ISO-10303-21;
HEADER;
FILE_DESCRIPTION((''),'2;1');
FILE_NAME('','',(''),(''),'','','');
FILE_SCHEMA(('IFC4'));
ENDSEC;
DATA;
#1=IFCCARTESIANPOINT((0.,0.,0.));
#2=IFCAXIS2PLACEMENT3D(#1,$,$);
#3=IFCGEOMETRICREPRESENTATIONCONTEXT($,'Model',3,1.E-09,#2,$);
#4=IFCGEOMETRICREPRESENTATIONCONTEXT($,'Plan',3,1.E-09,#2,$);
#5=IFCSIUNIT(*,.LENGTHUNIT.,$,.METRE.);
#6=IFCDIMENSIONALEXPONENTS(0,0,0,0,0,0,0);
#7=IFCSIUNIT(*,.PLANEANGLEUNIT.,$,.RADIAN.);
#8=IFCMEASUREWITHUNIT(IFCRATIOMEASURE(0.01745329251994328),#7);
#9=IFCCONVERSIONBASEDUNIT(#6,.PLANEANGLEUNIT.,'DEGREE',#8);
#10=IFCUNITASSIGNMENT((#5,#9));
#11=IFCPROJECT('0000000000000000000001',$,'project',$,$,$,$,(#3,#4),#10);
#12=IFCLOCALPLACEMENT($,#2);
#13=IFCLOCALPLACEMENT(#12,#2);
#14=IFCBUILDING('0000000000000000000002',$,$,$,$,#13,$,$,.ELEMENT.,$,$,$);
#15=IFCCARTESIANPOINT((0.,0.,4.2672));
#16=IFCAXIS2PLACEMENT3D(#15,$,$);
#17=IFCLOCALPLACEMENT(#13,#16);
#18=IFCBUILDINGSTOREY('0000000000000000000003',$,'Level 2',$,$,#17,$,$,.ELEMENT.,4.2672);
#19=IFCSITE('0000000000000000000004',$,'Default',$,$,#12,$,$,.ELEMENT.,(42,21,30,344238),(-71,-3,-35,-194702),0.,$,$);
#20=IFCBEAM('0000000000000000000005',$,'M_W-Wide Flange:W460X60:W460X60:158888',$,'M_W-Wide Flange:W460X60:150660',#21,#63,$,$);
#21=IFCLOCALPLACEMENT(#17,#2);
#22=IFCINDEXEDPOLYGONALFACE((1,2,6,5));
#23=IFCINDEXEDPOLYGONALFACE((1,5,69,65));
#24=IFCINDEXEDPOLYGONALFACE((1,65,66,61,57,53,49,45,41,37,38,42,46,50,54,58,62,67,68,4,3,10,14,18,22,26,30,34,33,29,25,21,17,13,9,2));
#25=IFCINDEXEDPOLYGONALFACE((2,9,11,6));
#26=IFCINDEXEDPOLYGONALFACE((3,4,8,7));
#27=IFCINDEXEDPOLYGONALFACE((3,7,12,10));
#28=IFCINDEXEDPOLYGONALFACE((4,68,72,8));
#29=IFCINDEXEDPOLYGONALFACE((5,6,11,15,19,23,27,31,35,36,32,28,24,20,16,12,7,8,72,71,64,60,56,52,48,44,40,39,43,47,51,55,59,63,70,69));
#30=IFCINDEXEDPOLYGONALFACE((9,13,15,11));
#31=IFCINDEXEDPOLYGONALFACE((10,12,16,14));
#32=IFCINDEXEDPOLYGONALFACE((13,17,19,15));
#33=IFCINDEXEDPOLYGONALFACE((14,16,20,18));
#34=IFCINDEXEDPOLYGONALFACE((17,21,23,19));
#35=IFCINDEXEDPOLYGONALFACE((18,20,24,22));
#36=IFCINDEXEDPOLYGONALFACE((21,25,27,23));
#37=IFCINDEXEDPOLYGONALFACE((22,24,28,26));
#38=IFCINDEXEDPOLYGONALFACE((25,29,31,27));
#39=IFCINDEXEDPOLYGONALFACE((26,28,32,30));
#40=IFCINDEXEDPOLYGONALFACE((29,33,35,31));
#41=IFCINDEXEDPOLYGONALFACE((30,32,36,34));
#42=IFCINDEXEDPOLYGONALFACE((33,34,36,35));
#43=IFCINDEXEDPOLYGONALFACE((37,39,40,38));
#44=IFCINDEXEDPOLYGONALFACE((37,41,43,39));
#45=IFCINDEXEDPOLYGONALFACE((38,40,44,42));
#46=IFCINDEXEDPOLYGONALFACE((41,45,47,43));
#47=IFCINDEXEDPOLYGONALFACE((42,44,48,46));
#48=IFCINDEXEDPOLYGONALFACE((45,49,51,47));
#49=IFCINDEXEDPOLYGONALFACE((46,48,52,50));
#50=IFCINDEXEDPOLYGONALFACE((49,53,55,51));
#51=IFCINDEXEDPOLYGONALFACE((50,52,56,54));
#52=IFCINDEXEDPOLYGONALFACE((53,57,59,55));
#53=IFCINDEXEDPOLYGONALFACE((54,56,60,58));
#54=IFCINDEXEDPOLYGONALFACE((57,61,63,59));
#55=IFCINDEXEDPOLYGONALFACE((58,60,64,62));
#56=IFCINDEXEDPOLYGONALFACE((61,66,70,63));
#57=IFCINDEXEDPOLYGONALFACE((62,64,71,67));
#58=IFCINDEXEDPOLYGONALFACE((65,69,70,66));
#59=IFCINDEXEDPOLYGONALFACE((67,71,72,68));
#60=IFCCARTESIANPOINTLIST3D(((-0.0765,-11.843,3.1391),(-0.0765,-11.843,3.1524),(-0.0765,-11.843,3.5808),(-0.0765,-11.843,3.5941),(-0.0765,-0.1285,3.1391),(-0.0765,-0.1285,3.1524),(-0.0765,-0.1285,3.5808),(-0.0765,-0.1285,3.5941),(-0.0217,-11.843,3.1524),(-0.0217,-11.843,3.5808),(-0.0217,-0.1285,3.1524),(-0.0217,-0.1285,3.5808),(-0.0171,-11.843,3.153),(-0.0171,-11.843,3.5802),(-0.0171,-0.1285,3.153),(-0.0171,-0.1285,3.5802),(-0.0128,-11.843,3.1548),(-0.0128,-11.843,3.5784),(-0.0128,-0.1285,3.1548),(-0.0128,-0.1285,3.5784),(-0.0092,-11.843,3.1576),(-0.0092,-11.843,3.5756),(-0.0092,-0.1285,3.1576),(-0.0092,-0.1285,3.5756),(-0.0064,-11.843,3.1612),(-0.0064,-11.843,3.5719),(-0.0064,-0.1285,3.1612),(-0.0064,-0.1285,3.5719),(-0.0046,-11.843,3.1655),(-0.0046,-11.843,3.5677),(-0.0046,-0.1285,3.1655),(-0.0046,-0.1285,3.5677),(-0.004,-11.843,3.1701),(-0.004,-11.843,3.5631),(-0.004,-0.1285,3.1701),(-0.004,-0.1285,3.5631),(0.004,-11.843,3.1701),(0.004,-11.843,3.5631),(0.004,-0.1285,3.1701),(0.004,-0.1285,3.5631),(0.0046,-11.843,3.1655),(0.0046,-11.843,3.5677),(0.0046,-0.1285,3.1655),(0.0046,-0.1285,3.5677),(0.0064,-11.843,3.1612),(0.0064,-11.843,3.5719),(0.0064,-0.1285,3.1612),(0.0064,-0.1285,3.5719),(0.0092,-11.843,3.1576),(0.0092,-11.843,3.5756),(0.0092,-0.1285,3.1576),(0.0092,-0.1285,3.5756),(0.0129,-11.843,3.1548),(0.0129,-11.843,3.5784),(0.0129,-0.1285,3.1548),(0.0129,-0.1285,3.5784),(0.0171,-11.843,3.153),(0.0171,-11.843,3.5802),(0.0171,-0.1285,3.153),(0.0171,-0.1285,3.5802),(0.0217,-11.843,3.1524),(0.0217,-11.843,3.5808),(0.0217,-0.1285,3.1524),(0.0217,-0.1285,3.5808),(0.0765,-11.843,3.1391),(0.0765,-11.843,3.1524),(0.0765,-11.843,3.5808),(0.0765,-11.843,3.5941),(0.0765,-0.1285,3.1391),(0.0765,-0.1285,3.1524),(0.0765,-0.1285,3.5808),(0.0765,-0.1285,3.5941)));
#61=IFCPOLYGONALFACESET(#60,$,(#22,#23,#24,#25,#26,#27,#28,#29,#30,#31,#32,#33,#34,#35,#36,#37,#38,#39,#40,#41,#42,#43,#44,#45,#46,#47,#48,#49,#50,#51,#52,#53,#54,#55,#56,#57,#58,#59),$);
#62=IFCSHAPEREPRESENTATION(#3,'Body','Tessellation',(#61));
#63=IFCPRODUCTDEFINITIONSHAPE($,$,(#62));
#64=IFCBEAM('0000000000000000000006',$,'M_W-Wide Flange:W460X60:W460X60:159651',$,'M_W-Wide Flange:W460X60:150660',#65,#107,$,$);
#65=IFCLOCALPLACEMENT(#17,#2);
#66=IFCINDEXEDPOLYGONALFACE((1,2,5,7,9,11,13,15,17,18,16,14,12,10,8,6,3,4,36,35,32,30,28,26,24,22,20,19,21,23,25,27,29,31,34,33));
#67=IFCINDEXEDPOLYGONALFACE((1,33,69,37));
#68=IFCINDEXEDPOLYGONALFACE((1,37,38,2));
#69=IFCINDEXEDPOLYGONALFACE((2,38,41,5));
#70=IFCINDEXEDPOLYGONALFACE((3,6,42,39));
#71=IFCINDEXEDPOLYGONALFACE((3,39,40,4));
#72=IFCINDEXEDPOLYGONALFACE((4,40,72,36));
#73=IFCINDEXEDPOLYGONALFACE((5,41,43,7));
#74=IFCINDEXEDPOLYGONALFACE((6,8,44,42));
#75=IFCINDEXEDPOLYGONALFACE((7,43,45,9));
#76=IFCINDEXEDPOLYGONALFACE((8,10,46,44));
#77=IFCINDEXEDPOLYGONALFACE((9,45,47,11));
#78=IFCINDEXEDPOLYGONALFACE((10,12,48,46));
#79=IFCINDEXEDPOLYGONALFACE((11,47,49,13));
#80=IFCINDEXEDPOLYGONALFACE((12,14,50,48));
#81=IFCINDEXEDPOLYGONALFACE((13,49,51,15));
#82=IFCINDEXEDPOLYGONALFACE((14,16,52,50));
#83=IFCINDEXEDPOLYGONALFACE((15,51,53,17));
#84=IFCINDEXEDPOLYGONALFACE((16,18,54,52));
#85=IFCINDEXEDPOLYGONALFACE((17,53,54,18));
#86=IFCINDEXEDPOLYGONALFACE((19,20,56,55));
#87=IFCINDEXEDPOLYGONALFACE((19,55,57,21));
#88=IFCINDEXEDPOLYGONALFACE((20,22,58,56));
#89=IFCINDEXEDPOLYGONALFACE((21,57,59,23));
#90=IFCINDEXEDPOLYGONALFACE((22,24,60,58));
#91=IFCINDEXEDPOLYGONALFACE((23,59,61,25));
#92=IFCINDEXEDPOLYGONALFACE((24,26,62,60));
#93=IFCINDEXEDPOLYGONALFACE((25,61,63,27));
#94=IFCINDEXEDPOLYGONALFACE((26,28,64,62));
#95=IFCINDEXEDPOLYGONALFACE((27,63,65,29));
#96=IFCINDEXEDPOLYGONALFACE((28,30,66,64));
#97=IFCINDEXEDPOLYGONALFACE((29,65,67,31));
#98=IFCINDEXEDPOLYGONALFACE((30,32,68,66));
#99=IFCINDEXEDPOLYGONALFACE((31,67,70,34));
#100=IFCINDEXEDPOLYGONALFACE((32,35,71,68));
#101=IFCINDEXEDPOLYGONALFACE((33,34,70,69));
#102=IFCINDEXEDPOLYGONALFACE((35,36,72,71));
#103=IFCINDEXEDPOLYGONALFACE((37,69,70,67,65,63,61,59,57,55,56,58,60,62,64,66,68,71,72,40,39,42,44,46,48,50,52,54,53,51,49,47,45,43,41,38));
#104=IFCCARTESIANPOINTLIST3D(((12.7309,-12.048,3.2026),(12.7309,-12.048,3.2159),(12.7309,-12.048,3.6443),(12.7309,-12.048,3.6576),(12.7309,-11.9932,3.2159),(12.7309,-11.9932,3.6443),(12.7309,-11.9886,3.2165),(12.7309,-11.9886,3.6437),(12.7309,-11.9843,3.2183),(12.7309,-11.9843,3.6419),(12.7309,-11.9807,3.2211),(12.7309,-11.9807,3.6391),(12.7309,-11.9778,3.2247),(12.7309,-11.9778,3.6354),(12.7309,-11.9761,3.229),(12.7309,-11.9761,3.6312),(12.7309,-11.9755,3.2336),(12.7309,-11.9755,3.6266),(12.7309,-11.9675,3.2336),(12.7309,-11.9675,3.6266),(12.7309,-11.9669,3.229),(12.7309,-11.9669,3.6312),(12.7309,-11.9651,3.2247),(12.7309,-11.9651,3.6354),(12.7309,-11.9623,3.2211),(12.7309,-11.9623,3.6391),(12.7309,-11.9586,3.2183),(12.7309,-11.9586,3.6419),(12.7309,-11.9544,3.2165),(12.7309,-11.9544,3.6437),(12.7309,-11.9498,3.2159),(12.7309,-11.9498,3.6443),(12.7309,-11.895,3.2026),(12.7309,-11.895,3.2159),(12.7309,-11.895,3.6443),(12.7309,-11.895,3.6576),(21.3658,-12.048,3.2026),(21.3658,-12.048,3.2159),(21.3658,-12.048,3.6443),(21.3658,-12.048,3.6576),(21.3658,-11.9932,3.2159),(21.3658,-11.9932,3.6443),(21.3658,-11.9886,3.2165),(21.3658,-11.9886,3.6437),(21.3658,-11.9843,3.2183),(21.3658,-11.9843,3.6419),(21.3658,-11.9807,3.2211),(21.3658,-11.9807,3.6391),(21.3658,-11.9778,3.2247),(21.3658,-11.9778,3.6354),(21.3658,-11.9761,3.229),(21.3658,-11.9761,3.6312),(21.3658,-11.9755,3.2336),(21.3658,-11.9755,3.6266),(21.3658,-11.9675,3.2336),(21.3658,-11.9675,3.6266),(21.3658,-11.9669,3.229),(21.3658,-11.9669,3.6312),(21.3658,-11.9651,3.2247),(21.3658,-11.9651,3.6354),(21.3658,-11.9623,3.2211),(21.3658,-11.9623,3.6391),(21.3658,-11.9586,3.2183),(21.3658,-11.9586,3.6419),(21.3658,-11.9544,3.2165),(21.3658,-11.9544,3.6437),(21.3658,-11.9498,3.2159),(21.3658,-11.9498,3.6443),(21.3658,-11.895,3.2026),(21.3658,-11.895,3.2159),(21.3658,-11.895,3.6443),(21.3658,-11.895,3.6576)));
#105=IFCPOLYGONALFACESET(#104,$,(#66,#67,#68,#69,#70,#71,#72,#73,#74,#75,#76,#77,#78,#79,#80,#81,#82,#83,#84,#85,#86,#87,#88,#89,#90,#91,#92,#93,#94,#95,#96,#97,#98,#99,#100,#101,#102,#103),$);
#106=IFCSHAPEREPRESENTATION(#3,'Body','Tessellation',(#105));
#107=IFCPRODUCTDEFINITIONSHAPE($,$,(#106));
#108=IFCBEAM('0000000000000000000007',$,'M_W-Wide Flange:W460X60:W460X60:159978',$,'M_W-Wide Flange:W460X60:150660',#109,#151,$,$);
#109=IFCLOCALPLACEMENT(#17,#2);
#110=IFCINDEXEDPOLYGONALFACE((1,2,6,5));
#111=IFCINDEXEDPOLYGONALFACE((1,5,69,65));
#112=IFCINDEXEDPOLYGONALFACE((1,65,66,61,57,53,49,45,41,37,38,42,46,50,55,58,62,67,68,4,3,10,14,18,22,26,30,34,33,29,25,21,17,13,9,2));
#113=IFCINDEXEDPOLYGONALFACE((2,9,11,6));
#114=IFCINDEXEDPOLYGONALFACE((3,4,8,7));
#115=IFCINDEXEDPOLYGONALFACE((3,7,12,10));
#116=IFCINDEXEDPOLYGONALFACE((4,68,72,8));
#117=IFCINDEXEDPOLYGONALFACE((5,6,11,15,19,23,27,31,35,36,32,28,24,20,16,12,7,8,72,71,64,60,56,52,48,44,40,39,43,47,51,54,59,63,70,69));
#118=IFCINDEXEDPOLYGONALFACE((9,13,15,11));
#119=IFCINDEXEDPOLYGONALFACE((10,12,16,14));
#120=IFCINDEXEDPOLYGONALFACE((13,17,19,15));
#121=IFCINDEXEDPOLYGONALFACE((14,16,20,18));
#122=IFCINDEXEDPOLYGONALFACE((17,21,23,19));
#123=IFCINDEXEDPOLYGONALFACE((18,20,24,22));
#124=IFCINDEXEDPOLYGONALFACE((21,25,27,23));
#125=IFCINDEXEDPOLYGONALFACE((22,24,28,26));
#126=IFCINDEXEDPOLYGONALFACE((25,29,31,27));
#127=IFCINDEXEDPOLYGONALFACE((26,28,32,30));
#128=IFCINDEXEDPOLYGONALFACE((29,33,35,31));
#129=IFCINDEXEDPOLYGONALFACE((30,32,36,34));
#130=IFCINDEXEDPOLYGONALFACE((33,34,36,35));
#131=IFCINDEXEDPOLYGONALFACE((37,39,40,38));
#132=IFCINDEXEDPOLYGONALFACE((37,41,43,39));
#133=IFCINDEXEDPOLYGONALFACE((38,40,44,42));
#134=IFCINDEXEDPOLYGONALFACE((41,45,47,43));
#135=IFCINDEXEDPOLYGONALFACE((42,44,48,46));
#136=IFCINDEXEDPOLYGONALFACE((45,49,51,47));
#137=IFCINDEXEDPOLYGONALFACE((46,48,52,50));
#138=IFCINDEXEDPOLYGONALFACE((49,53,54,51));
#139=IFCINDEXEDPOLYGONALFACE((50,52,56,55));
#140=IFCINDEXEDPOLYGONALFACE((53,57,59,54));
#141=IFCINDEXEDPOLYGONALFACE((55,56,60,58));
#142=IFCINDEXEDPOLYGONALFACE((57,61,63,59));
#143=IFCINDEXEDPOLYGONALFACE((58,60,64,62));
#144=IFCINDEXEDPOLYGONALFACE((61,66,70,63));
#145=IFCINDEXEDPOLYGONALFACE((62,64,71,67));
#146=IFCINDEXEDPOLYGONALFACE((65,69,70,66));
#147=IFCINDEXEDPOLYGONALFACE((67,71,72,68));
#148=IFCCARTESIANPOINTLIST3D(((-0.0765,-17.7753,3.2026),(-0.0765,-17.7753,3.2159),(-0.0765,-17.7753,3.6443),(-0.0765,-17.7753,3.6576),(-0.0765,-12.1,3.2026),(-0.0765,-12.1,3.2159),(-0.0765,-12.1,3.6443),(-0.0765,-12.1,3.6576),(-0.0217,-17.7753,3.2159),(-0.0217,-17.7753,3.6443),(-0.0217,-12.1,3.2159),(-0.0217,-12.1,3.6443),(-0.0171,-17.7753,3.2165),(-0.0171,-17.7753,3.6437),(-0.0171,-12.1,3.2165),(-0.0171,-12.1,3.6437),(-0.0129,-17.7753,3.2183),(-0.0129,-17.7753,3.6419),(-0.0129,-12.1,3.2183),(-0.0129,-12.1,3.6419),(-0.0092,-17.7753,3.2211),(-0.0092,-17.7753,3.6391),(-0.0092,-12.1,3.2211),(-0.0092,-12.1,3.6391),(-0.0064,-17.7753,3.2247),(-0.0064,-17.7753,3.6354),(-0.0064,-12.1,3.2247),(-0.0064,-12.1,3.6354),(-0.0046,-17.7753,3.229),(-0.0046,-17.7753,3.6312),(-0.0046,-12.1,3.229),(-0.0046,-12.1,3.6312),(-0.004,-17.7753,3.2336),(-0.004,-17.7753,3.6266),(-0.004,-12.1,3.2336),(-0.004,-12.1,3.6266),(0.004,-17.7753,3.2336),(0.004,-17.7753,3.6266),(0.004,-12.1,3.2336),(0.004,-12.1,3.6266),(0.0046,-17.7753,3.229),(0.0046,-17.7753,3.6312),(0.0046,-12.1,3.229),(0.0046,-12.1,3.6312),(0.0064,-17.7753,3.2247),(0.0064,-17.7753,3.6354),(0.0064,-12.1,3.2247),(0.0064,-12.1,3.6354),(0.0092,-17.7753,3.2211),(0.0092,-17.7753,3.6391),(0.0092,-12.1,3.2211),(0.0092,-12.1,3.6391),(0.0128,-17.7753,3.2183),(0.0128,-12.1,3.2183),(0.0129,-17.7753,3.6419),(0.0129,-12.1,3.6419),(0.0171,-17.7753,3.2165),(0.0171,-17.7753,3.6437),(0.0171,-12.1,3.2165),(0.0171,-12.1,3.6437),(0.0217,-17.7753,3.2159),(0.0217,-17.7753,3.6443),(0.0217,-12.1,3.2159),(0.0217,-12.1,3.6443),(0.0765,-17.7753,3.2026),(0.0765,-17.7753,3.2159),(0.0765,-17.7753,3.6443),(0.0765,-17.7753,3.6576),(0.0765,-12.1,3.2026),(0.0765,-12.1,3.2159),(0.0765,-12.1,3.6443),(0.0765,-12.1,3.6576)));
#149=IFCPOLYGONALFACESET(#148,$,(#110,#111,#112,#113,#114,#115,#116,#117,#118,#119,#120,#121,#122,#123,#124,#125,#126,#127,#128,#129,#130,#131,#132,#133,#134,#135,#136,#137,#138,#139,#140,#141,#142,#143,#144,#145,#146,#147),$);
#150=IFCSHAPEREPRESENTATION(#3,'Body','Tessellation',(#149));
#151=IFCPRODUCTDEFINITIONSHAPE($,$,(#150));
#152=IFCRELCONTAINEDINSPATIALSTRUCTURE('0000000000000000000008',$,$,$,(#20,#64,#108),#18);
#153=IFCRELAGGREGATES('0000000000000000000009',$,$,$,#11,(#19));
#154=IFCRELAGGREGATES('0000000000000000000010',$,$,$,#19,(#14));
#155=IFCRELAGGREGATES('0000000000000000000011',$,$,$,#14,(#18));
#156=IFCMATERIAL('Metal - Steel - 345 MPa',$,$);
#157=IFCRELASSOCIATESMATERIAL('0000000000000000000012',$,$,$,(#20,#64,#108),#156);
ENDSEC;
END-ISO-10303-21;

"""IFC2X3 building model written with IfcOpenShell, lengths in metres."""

from ifc_helpers import new_model, entity, si_unit, converted_unit, frame, frame_2d, origin, place, context, project, spatial, polyline, circle_curve, parameter, trimmed, segment, composite_curve, outline, extrude, material, element, save


model = new_model("IFC2X3")

# Units and contexts
model_context = context("Model", 3, precision=1e-09, world=origin())
plan_context = context("Plan", 3, precision=1e-09, world=origin())
ifc_project = project(units=[si_unit("LENGTHUNIT", "METRE"), converted_unit("PLANEANGLEUNIT", "DEGREE", entity("IfcRatioMeasure", 0.01745329251994328), si_unit("PLANEANGLEUNIT", "RADIAN"), dimensions=[0, 0, 0, 0, 0, 0, 0])], contexts=[model_context, plan_context])

# Site, building, storey
site_placement = place(None, origin())
site = spatial("IfcSite", under=ifc_project, at=site_placement, Name="Default", CompositionType="ELEMENT", RefLatitude=(42, 21, 30, 344238), RefLongitude=(-71, -3, -35, -194702), RefElevation=0.0)
building_placement = place(site_placement, origin())
building = spatial("IfcBuilding", under=site, at=building_placement, CompositionType="ELEMENT")
storey_placement = place(building_placement, frame((0.0, 0.0, 4.2672)))
storey = spatial("IfcBuildingStorey", under=building, at=storey_placement, Name="Level 2", CompositionType="ELEMENT", Elevation=4.2672)

# Shared definitions
ifc_material = material(Name="Metal - Steel - 345 MPa")

# Beams
beam_1_placement = place(storey_placement, frame((0.0, 0.0, 3.6576), z_axis=(0.0, 0.0, 1.0), x_axis=(-1.0, 0.0, 0.0)))
element("IfcBeam", 1, at=beam_1_placement, inside=storey, material=ifc_material, Name="M_W-Wide Flange:W460X60:W460X60:158888", ObjectType="M_W-Wide Flange:W460X60:150660", context=model_context, shape_type="SweptSolid", body=[
    extrude(outline(composite_curve([segment(polyline([(0.2142, -0.0765), (0.2275, -0.0765)]), True, "CONTINUOUS"), segment(polyline([(0.2275, -0.0765), (0.2275, 0.0765)]), True, "CONTINUOUS"), segment(polyline([(0.2275, 0.0765), (0.2142, 0.0765)]), True, "CONTINUOUS"), segment(polyline([(0.2142, 0.0765), (0.2142, 0.0217)]), True, "CONTINUOUS"), segment(trimmed(circle_curve(frame_2d((0.1965, 0.0217), x_axis=(0.0, 1.0)), 0.0177), [parameter(180.0)], [parameter(270.0)], True, "PARAMETER"), False, "CONTINUOUS"), segment(polyline([(0.1965, 0.004), (-0.1965, 0.004)]), True, "CONTINUOUS"), segment(trimmed(circle_curve(frame_2d((-0.1965, 0.0217), x_axis=(0.0, 1.0)), 0.0177), [parameter(90.0)], [parameter(180.0)], True, "PARAMETER"), False, "CONTINUOUS"), segment(polyline([(-0.2142, 0.0217), (-0.2142, 0.0765)]), True, "CONTINUOUS"), segment(polyline([(-0.2142, 0.0765), (-0.2275, 0.0765)]), True, "CONTINUOUS"), segment(polyline([(-0.2275, 0.0765), (-0.2275, -0.0765)]), True, "CONTINUOUS"), segment(polyline([(-0.2275, -0.0765), (-0.2142, -0.0765)]), True, "CONTINUOUS"), segment(polyline([(-0.2142, -0.0765), (-0.2142, -0.0217)]), True, "CONTINUOUS"), segment(trimmed(circle_curve(frame_2d((-0.1965, -0.0217), x_axis=(0.0, 1.0)), 0.0177), [parameter(360.0)], [parameter(90.0)], True, "PARAMETER"), False, "CONTINUOUS"), segment(polyline([(-0.1965, -0.004), (0.1965, -0.004)]), True, "CONTINUOUS"), segment(trimmed(circle_curve(frame_2d((0.1965, -0.0217), x_axis=(0.0, 1.0)), 0.0177), [parameter(270.0)], [parameter(0.0)], True, "PARAMETER"), False, "CONTINUOUS"), segment(polyline([(0.2142, -0.0217), (0.2142, -0.0765)]), True, "CONTINUOUS")], self_intersect=False)), frame((0.0, 11.843, -0.291), z_axis=(0.0, -1.0, 0.0), x_axis=(0.0, 0.0, -1.0)), (0.0, 0.0, 1.0), 11.7145),
])
beam_2_placement = place(storey_placement, frame((21.4678, -11.9715, 3.6576), z_axis=(0.0, 0.0, 1.0), x_axis=(0.0, 1.0, 0.0)))
element("IfcBeam", 2, at=beam_2_placement, inside=storey, material=ifc_material, Name="M_W-Wide Flange:W460X60:W460X60:159651", ObjectType="M_W-Wide Flange:W460X60:150660", context=model_context, shape_type="SweptSolid", body=[
    extrude(outline(composite_curve([segment(polyline([(0.2142, -0.0765), (0.2275, -0.0765)]), True, "CONTINUOUS"), segment(polyline([(0.2275, -0.0765), (0.2275, 0.0765)]), True, "CONTINUOUS"), segment(polyline([(0.2275, 0.0765), (0.2142, 0.0765)]), True, "CONTINUOUS"), segment(polyline([(0.2142, 0.0765), (0.2142, 0.0217)]), True, "CONTINUOUS"), segment(trimmed(circle_curve(frame_2d((0.1965, 0.0217), x_axis=(1.0, 0.0)), 0.0177), [parameter(270.0)], [parameter(360.0)], True, "PARAMETER"), False, "CONTINUOUS"), segment(polyline([(0.1965, 0.004), (-0.1965, 0.004)]), True, "CONTINUOUS"), segment(trimmed(circle_curve(frame_2d((-0.1965, 0.0217), x_axis=(0.0, -1.0)), 0.0177), [parameter(270.0)], [parameter(360.0)], True, "PARAMETER"), False, "CONTINUOUS"), segment(polyline([(-0.2142, 0.0217), (-0.2142, 0.0765)]), True, "CONTINUOUS"), segment(polyline([(-0.2142, 0.0765), (-0.2275, 0.0765)]), True, "CONTINUOUS"), segment(polyline([(-0.2275, 0.0765), (-0.2275, -0.0765)]), True, "CONTINUOUS"), segment(polyline([(-0.2275, -0.0765), (-0.2142, -0.0765)]), True, "CONTINUOUS"), segment(polyline([(-0.2142, -0.0765), (-0.2142, -0.0217)]), True, "CONTINUOUS"), segment(trimmed(circle_curve(frame_2d((-0.1965, -0.0217), x_axis=(-1.0, 0.0)), 0.0177), [parameter(270.0)], [parameter(360.0)], True, "PARAMETER"), False, "CONTINUOUS"), segment(polyline([(-0.1965, -0.004), (0.1965, -0.004)]), True, "CONTINUOUS"), segment(trimmed(circle_curve(frame_2d((0.1965, -0.0217), x_axis=(0.0, 1.0)), 0.0177), [parameter(270.0)], [parameter(0.0)], True, "PARAMETER"), False, "CONTINUOUS"), segment(polyline([(0.2142, -0.0217), (0.2142, -0.0765)]), True, "CONTINUOUS")], self_intersect=False)), frame((0.0, 8.7369, -0.2275), z_axis=(0.0, -1.0, 0.0), x_axis=(0.0, 0.0, -1.0)), (0.0, 0.0, 1.0), 8.6349),
])
beam_3_placement = place(storey_placement, frame((0.0, -17.9038, 3.6576)))
element("IfcBeam", 3, at=beam_3_placement, inside=storey, material=ifc_material, Name="M_W-Wide Flange:W460X60:W460X60:159978", ObjectType="M_W-Wide Flange:W460X60:150660", context=model_context, shape_type="SweptSolid", body=[
    extrude(outline(composite_curve([segment(polyline([(-0.0765, -0.2142), (-0.0765, -0.2275)]), True, "CONTINUOUS"), segment(polyline([(-0.0765, -0.2275), (0.0765, -0.2275)]), True, "CONTINUOUS"), segment(polyline([(0.0765, -0.2275), (0.0765, -0.2142)]), True, "CONTINUOUS"), segment(polyline([(0.0765, -0.2142), (0.0217, -0.2142)]), True, "CONTINUOUS"), segment(trimmed(circle_curve(frame_2d((0.0217, -0.1965), x_axis=(0.0, -1.0)), 0.0177), [parameter(270.0)], [parameter(360.0)], True, "PARAMETER"), False, "CONTINUOUS"), segment(polyline([(0.004, -0.1965), (0.004, 0.1965)]), True, "CONTINUOUS"), segment(trimmed(circle_curve(frame_2d((0.0217, 0.1965), x_axis=(-1.0, 0.0)), 0.0177), [parameter(270.0)], [parameter(360.0)], True, "PARAMETER"), False, "CONTINUOUS"), segment(polyline([(0.0217, 0.2142), (0.0765, 0.2142)]), True, "CONTINUOUS"), segment(polyline([(0.0765, 0.2142), (0.0765, 0.2275)]), True, "CONTINUOUS"), segment(polyline([(0.0765, 0.2275), (-0.0765, 0.2275)]), True, "CONTINUOUS"), segment(polyline([(-0.0765, 0.2275), (-0.0765, 0.2142)]), True, "CONTINUOUS"), segment(polyline([(-0.0765, 0.2142), (-0.0217, 0.2142)]), True, "CONTINUOUS"), segment(trimmed(circle_curve(frame_2d((-0.0217, 0.1965), x_axis=(0.0, 1.0)), 0.0177), [parameter(270.0)], [parameter(360.0)], True, "PARAMETER"), False, "CONTINUOUS"), segment(polyline([(-0.004, 0.1965), (-0.004, -0.1965)]), True, "CONTINUOUS"), segment(trimmed(circle_curve(frame_2d((-0.0217, -0.1965), x_axis=(1.0, 0.0)), 0.0177), [parameter(270.0)], [parameter(0.0)], True, "PARAMETER"), False, "CONTINUOUS"), segment(polyline([(-0.0217, -0.2142), (-0.0765, -0.2142)]), True, "CONTINUOUS")], self_intersect=False)), frame((0.0, 0.1285, -0.2275), z_axis=(0.0, -1.0, 0.0), x_axis=(1.0, 0.0, 0.0)), (0.0, 0.0, -1.0), 5.6754),
])

save(model, "model.ifc")
